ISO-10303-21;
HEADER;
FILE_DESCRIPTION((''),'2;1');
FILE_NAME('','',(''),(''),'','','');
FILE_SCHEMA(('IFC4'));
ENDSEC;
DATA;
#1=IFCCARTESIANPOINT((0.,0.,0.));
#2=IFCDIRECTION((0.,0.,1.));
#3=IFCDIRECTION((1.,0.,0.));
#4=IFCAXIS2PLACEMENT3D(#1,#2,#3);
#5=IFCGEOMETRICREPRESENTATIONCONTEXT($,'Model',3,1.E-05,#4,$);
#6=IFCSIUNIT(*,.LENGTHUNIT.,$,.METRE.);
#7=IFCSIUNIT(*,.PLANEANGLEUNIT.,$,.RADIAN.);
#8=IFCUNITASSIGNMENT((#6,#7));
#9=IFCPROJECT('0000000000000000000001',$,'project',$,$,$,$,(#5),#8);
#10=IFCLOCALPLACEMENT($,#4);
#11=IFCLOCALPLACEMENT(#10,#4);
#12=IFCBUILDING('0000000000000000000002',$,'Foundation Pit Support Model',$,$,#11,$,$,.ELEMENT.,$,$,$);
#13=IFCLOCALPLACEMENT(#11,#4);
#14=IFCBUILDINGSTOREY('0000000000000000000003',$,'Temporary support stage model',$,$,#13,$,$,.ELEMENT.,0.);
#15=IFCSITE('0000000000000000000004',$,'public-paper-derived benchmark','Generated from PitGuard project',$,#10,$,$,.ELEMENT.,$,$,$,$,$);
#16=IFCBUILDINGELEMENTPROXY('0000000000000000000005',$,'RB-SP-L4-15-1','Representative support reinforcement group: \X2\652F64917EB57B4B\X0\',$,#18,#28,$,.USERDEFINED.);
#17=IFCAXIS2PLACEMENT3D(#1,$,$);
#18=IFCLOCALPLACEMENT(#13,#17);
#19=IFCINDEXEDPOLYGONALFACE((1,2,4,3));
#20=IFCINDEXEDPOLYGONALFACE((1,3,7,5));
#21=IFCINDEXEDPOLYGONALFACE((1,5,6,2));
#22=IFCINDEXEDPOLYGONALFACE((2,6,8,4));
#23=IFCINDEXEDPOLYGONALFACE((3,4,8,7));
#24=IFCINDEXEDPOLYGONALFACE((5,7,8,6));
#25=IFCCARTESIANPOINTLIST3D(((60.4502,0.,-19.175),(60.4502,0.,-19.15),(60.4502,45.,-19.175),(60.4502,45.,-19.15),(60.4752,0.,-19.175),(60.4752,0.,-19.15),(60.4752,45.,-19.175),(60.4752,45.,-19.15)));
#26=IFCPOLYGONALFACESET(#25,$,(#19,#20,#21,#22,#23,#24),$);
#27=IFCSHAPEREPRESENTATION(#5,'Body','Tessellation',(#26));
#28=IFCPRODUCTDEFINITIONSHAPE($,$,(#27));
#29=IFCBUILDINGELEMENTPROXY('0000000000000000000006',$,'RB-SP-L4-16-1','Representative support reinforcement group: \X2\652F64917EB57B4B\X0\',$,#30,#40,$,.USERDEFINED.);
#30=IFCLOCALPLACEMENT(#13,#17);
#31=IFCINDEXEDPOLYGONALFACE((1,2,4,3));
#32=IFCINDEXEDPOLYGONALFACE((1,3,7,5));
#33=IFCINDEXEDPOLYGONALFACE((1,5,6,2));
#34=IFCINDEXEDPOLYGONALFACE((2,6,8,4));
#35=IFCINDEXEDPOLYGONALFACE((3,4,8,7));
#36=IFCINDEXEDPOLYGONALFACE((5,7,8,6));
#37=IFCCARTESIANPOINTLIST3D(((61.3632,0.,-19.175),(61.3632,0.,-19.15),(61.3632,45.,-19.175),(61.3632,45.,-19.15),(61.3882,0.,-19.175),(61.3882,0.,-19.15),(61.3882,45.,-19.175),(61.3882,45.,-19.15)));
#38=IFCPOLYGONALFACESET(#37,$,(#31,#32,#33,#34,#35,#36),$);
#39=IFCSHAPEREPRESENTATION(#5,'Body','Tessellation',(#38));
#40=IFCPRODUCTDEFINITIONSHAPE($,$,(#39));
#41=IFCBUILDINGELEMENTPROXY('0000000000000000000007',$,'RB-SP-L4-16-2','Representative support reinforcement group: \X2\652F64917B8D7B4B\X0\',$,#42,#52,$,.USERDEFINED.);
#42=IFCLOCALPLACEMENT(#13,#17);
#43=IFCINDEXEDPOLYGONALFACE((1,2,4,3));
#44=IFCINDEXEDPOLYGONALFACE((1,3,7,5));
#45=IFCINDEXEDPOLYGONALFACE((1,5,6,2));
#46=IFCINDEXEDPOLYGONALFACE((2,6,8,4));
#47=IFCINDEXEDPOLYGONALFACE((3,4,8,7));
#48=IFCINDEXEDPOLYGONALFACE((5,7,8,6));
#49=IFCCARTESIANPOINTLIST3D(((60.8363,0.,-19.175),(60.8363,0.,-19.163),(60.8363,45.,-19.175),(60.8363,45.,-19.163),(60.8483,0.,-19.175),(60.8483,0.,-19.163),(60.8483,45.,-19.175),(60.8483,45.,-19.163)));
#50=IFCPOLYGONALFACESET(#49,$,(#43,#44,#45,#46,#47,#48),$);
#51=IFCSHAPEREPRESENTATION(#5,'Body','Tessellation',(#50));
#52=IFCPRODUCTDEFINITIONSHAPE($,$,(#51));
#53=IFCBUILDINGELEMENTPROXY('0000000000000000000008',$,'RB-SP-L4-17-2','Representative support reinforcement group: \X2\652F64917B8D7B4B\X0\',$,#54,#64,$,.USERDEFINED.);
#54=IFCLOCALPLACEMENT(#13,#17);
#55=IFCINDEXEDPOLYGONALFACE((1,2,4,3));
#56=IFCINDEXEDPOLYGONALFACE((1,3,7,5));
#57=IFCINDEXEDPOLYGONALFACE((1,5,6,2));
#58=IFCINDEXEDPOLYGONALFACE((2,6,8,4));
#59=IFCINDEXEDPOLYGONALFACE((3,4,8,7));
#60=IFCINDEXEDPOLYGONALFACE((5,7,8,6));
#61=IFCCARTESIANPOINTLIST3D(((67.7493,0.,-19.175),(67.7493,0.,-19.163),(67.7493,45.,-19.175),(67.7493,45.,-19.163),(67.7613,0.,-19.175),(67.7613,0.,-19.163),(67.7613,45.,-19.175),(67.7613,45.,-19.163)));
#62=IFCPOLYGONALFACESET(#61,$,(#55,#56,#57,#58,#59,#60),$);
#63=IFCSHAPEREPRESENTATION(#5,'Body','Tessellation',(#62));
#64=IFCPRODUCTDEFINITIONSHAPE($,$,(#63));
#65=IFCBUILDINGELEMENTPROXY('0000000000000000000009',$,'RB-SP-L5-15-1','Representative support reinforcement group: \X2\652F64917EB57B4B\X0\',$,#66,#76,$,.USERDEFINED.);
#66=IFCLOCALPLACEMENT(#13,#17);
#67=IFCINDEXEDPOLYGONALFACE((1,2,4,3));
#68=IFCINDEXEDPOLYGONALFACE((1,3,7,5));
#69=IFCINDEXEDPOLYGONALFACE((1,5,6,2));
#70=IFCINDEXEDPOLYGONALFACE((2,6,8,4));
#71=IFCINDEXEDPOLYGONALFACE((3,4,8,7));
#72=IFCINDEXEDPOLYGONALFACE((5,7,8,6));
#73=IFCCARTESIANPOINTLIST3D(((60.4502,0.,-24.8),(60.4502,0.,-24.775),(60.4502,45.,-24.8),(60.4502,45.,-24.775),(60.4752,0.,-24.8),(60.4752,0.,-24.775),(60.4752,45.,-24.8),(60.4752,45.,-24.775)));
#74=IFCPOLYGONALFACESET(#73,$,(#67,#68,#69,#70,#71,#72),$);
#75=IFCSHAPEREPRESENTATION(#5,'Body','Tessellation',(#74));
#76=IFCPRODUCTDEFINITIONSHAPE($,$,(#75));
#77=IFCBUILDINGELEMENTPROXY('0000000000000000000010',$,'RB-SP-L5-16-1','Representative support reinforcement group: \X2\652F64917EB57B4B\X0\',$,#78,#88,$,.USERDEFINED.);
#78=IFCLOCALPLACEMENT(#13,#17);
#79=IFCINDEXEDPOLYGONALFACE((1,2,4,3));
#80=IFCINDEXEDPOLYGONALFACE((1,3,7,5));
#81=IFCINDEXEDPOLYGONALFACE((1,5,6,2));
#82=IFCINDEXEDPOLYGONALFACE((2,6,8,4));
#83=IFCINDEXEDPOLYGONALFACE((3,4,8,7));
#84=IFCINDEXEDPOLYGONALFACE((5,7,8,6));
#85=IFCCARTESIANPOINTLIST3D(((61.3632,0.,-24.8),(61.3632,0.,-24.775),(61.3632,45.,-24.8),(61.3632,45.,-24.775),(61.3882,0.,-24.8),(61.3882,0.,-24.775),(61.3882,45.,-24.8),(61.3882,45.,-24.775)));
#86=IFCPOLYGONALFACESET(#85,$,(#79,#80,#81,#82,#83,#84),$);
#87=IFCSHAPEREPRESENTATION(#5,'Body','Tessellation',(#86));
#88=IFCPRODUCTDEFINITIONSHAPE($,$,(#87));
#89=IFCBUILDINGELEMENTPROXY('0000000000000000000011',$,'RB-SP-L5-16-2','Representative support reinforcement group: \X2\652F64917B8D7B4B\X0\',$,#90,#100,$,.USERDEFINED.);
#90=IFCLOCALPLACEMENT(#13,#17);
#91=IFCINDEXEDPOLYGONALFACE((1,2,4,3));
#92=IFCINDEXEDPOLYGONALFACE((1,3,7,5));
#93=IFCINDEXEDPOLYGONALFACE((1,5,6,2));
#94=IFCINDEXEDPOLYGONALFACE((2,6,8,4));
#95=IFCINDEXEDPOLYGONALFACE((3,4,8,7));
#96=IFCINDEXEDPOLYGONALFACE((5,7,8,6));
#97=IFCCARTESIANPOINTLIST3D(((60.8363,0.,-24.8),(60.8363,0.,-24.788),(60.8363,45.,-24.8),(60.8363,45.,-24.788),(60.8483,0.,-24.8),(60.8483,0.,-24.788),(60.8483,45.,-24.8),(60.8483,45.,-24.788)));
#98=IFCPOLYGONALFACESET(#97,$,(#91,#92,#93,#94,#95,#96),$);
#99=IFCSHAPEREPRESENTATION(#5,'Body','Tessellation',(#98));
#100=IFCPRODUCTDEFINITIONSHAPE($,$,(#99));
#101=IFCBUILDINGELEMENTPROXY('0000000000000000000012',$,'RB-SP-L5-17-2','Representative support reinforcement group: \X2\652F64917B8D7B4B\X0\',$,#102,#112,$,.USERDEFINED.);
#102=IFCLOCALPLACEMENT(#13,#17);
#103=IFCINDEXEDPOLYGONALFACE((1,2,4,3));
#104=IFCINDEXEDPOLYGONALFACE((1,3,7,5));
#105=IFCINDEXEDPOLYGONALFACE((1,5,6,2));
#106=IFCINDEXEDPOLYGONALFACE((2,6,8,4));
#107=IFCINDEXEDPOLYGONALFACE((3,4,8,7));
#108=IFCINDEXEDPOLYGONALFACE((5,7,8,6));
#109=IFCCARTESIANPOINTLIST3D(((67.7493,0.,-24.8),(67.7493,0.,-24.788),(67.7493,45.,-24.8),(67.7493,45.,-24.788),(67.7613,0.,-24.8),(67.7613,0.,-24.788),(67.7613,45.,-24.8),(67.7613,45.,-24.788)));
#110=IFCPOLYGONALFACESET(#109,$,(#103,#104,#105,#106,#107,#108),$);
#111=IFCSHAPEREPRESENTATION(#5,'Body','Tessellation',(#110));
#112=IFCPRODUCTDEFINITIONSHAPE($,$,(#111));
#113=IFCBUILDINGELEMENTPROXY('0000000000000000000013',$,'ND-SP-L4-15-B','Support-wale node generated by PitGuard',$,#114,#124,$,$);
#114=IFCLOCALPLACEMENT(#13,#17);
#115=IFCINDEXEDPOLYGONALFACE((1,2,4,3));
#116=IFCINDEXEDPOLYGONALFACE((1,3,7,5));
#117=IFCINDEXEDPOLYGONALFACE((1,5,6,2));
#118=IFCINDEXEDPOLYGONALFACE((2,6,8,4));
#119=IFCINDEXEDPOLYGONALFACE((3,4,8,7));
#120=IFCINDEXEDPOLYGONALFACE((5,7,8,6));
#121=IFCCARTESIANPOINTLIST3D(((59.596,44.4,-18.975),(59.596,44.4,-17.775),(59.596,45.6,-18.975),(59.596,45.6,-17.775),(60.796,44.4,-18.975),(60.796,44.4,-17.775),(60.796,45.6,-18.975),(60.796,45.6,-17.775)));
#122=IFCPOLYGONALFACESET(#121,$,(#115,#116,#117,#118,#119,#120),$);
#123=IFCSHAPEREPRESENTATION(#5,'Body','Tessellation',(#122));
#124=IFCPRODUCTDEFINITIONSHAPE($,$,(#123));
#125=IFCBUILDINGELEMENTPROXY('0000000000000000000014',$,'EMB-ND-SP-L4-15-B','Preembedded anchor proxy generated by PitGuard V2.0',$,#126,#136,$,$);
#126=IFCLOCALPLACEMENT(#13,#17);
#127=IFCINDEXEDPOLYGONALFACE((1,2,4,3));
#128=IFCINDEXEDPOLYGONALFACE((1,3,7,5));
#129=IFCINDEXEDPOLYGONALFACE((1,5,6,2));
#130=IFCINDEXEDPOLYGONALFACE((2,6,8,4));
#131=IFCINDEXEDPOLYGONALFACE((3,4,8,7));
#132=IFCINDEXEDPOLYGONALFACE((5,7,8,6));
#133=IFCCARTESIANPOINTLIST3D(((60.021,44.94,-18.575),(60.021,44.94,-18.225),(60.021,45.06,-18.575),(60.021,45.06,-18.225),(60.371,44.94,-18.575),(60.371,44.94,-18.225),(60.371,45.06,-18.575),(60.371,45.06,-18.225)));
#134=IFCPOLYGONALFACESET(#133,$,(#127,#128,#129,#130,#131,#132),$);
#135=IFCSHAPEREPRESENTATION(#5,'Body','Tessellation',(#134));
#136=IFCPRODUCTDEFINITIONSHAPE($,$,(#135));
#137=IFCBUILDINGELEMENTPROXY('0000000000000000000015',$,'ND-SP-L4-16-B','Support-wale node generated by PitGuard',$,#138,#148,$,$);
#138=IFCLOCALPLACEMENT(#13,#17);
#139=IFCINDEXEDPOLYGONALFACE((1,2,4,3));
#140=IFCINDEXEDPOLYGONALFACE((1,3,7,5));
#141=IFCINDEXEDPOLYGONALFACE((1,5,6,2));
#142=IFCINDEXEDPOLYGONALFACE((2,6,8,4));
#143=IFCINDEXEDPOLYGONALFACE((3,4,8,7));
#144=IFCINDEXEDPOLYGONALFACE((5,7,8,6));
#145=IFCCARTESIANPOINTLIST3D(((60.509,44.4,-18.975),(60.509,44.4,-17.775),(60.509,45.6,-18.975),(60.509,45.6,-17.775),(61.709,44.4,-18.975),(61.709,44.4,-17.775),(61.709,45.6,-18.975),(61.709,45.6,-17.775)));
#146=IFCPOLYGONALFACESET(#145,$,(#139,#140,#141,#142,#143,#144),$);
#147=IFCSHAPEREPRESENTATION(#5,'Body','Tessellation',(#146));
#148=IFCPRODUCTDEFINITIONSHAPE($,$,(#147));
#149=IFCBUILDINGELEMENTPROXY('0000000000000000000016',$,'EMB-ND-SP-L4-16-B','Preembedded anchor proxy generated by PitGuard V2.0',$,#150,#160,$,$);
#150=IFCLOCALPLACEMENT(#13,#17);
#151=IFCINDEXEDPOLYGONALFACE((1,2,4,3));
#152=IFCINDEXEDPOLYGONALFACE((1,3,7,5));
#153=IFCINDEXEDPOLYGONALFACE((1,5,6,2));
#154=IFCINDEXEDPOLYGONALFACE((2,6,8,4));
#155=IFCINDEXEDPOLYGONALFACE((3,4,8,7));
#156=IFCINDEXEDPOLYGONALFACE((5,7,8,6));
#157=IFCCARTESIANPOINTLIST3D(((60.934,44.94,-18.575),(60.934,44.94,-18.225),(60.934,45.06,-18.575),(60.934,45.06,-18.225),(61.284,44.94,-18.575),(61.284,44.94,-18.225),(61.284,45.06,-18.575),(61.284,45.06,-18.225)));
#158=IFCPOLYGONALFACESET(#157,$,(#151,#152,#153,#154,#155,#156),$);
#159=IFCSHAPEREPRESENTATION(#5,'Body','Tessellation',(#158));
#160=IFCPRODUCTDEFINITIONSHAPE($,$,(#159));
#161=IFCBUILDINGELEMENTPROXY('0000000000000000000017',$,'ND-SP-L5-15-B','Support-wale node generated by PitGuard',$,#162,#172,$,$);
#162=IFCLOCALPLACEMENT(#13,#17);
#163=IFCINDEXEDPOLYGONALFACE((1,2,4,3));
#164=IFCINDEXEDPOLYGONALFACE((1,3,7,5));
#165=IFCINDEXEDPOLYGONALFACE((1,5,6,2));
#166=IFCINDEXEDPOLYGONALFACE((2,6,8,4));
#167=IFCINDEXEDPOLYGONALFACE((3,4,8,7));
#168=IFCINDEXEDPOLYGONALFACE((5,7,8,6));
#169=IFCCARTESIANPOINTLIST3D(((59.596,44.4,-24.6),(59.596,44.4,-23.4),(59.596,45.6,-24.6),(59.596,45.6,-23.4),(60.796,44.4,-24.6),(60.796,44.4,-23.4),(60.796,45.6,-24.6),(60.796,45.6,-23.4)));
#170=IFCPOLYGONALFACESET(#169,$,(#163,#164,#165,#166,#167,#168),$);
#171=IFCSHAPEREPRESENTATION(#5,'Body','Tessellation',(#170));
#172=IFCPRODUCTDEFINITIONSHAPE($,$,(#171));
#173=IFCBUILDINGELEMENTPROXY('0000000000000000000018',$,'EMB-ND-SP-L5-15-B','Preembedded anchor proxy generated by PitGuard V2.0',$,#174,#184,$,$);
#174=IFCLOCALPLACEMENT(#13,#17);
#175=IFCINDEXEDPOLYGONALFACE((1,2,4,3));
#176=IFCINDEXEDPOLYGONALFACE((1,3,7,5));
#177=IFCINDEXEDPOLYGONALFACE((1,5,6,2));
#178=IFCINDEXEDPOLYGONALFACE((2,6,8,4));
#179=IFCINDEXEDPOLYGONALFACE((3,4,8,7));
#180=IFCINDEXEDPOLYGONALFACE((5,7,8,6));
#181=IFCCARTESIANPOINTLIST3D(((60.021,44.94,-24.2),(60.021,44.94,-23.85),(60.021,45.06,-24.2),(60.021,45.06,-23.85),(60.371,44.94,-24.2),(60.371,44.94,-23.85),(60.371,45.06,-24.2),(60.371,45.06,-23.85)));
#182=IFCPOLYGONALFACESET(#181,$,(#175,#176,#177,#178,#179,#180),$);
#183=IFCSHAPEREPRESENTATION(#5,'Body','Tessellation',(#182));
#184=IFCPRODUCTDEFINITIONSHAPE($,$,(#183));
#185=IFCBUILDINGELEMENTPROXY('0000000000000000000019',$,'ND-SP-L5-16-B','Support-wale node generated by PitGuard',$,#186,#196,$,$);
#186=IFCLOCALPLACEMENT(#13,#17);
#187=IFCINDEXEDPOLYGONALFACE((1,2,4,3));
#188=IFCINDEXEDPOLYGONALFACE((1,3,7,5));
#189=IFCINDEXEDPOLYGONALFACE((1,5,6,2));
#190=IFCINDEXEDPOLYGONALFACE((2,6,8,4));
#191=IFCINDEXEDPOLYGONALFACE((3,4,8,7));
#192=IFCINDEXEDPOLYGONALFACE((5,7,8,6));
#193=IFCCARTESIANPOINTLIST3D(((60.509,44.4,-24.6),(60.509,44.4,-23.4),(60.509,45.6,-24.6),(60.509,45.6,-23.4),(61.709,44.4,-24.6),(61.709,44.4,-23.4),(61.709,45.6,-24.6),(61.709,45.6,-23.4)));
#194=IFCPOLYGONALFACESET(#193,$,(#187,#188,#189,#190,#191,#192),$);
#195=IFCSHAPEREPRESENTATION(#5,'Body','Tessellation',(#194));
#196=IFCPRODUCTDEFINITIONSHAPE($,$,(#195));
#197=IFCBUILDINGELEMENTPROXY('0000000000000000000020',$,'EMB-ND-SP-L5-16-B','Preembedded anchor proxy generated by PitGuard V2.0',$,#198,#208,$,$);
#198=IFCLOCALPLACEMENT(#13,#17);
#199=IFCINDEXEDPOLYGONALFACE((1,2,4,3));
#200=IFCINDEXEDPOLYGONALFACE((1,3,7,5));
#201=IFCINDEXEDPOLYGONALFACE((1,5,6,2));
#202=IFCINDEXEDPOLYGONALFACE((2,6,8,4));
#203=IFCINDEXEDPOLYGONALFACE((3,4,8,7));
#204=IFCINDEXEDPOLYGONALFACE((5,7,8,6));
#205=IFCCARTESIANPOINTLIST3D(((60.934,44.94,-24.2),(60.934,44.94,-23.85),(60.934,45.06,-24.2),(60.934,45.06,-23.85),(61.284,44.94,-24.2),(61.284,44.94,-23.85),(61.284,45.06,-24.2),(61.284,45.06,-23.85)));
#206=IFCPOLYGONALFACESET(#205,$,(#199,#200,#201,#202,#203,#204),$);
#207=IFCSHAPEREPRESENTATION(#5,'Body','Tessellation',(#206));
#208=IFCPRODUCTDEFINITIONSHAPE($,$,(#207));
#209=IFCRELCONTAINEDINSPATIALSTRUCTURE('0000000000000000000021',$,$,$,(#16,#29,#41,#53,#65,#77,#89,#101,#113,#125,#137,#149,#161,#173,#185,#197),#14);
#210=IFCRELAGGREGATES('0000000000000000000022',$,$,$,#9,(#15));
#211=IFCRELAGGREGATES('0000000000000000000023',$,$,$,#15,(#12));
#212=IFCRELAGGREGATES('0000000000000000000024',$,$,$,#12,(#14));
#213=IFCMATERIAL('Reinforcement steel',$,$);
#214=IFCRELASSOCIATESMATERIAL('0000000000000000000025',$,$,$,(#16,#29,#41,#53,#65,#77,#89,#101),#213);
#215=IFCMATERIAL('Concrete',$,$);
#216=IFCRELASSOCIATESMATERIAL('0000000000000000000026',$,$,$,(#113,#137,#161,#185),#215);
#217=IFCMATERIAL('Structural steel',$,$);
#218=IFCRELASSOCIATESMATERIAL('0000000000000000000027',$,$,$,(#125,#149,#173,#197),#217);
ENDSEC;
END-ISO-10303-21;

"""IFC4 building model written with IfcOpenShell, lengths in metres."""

from ifc_helpers import new_model, si_unit, frame, origin_with_axes, origin_2d, place, context, project, spatial, rectangle, extrude, material, element, save


model = new_model("IFC4")

# Units and contexts
model_context = context("Model", 3, precision=1e-05, world=origin_with_axes())
ifc_project = project(units=[si_unit("LENGTHUNIT", "METRE"), si_unit("PLANEANGLEUNIT", "RADIAN")], contexts=[model_context])

# Site, building, storey
site_placement = place(None, origin_with_axes())
site = spatial("IfcSite", under=ifc_project, at=site_placement, Name="public-paper-derived benchmark", Description="Generated from PitGuard project", CompositionType="ELEMENT")
building_placement = place(site_placement, origin_with_axes())
building = spatial("IfcBuilding", under=site, at=building_placement, Name="Foundation Pit Support Model", CompositionType="ELEMENT")
storey_placement = place(building_placement, origin_with_axes())
storey = spatial("IfcBuildingStorey", under=building, at=storey_placement, Name="Temporary support stage model", CompositionType="ELEMENT", Elevation=0.0)

# Shared definitions
ifc_material_1 = material(Name="Structural steel")

# Shared definitions
ifc_material_2 = material(Name="Concrete")

# Building element proxies
ifc_material_3 = material(Name="Reinforcement steel")
for number, where, z_axis, x_axis, name in (
    (1, (60.4627, 22.5, -19.175), (0.0, 0.0, 1.0), (0.0, 1.0, 0.0), "RB-SP-L4-15-1"),
    (2, (61.3757, 22.5, -19.175), (0.0, 0.0, 1.0), (0.0, 1.0, 0.0), "RB-SP-L4-16-1"),
):
    element("IfcBuildingElementProxy", number, at=place(storey_placement, frame(where, z_axis=z_axis, x_axis=x_axis)), inside=storey, material=ifc_material_3, Name=name, Description="Representative support reinforcement group: 支撑纵筋", PredefinedType="USERDEFINED", context=model_context, shape_type="SweptSolid", body=[
        extrude(rectangle(XDim=45.0, YDim=0.025, at=origin_2d()), origin_with_axes(), (0.0, 0.0, 1.0), 0.025),
    ])
for number, where, z_axis, x_axis, name in (
    (3, (60.8423, 22.5, -19.175), (0.0, 0.0, 1.0), (0.0, 1.0, 0.0), "RB-SP-L4-16-2"),
    (4, (67.7553, 22.5, -19.175), (0.0, 0.0, 1.0), (0.0, 1.0, 0.0), "RB-SP-L4-17-2"),
):
    element("IfcBuildingElementProxy", number, at=place(storey_placement, frame(where, z_axis=z_axis, x_axis=x_axis)), inside=storey, material=ifc_material_3, Name=name, Description="Representative support reinforcement group: 支撑箍筋", PredefinedType="USERDEFINED", context=model_context, shape_type="SweptSolid", body=[
        extrude(rectangle(XDim=45.0, YDim=0.012, at=origin_2d()), origin_with_axes(), (0.0, 0.0, 1.0), 0.012),
    ])
for number, where, z_axis, x_axis, name in (
    (5, (60.4627, 22.5, -24.8), (0.0, 0.0, 1.0), (0.0, 1.0, 0.0), "RB-SP-L5-15-1"),
    (6, (61.3757, 22.5, -24.8), (0.0, 0.0, 1.0), (0.0, 1.0, 0.0), "RB-SP-L5-16-1"),
):
    element("IfcBuildingElementProxy", number, at=place(storey_placement, frame(where, z_axis=z_axis, x_axis=x_axis)), inside=storey, material=ifc_material_3, Name=name, Description="Representative support reinforcement group: 支撑纵筋", PredefinedType="USERDEFINED", context=model_context, shape_type="SweptSolid", body=[
        extrude(rectangle(XDim=45.0, YDim=0.025, at=origin_2d()), origin_with_axes(), (0.0, 0.0, 1.0), 0.025),
    ])
for number, where, z_axis, x_axis, name in (
    (7, (60.8423, 22.5, -24.8), (0.0, 0.0, 1.0), (0.0, 1.0, 0.0), "RB-SP-L5-16-2"),
    (8, (67.7553, 22.5, -24.8), (0.0, 0.0, 1.0), (0.0, 1.0, 0.0), "RB-SP-L5-17-2"),
):
    element("IfcBuildingElementProxy", number, at=place(storey_placement, frame(where, z_axis=z_axis, x_axis=x_axis)), inside=storey, material=ifc_material_3, Name=name, Description="Representative support reinforcement group: 支撑箍筋", PredefinedType="USERDEFINED", context=model_context, shape_type="SweptSolid", body=[
        extrude(rectangle(XDim=45.0, YDim=0.012, at=origin_2d()), origin_with_axes(), (0.0, 0.0, 1.0), 0.012),
    ])
proxy_1_placement = place(storey_placement, frame((60.196, 45.0, -18.975), z_axis=(0.0, 0.0, 1.0), x_axis=(1.0, 0.0, 0.0)))
element("IfcBuildingElementProxy", 9, at=proxy_1_placement, inside=storey, material=ifc_material_2, Name="ND-SP-L4-15-B", Description="Support-wale node generated by PitGuard", context=model_context, shape_type="SweptSolid", body=[
    extrude(rectangle(XDim=1.2, YDim=1.2, at=origin_2d()), origin_with_axes(), (0.0, 0.0, 1.0), 1.2),
])
proxy_2_placement = place(storey_placement, frame((60.196, 45.0, -18.575), z_axis=(0.0, 0.0, 1.0), x_axis=(1.0, 0.0, 0.0)))
element("IfcBuildingElementProxy", 10, at=proxy_2_placement, inside=storey, material=ifc_material_1, Name="EMB-ND-SP-L4-15-B", Description="Preembedded anchor proxy generated by PitGuard V2.0", context=model_context, shape_type="SweptSolid", body=[
    extrude(rectangle(XDim=0.35, YDim=0.12, at=origin_2d()), origin_with_axes(), (0.0, 0.0, 1.0), 0.35),
])
proxy_3_placement = place(storey_placement, frame((61.109, 45.0, -18.975), z_axis=(0.0, 0.0, 1.0), x_axis=(1.0, 0.0, 0.0)))
element("IfcBuildingElementProxy", 11, at=proxy_3_placement, inside=storey, material=ifc_material_2, Name="ND-SP-L4-16-B", Description="Support-wale node generated by PitGuard", context=model_context, shape_type="SweptSolid", body=[
    extrude(rectangle(XDim=1.2, YDim=1.2, at=origin_2d()), origin_with_axes(), (0.0, 0.0, 1.0), 1.2),
])
proxy_4_placement = place(storey_placement, frame((61.109, 45.0, -18.575), z_axis=(0.0, 0.0, 1.0), x_axis=(1.0, 0.0, 0.0)))
element("IfcBuildingElementProxy", 12, at=proxy_4_placement, inside=storey, material=ifc_material_1, Name="EMB-ND-SP-L4-16-B", Description="Preembedded anchor proxy generated by PitGuard V2.0", context=model_context, shape_type="SweptSolid", body=[
    extrude(rectangle(XDim=0.35, YDim=0.12, at=origin_2d()), origin_with_axes(), (0.0, 0.0, 1.0), 0.35),
])
proxy_5_placement = place(storey_placement, frame((60.196, 45.0, -24.6), z_axis=(0.0, 0.0, 1.0), x_axis=(1.0, 0.0, 0.0)))
element("IfcBuildingElementProxy", 13, at=proxy_5_placement, inside=storey, material=ifc_material_2, Name="ND-SP-L5-15-B", Description="Support-wale node generated by PitGuard", context=model_context, shape_type="SweptSolid", body=[
    extrude(rectangle(XDim=1.2, YDim=1.2, at=origin_2d()), origin_with_axes(), (0.0, 0.0, 1.0), 1.2),
])
proxy_6_placement = place(storey_placement, frame((60.196, 45.0, -24.2), z_axis=(0.0, 0.0, 1.0), x_axis=(1.0, 0.0, 0.0)))
element("IfcBuildingElementProxy", 14, at=proxy_6_placement, inside=storey, material=ifc_material_1, Name="EMB-ND-SP-L5-15-B", Description="Preembedded anchor proxy generated by PitGuard V2.0", context=model_context, shape_type="SweptSolid", body=[
    extrude(rectangle(XDim=0.35, YDim=0.12, at=origin_2d()), origin_with_axes(), (0.0, 0.0, 1.0), 0.35),
])
proxy_7_placement = place(storey_placement, frame((61.109, 45.0, -24.6), z_axis=(0.0, 0.0, 1.0), x_axis=(1.0, 0.0, 0.0)))
element("IfcBuildingElementProxy", 15, at=proxy_7_placement, inside=storey, material=ifc_material_2, Name="ND-SP-L5-16-B", Description="Support-wale node generated by PitGuard", context=model_context, shape_type="SweptSolid", body=[
    extrude(rectangle(XDim=1.2, YDim=1.2, at=origin_2d()), origin_with_axes(), (0.0, 0.0, 1.0), 1.2),
])
proxy_8_placement = place(storey_placement, frame((61.109, 45.0, -24.2), z_axis=(0.0, 0.0, 1.0), x_axis=(1.0, 0.0, 0.0)))
element("IfcBuildingElementProxy", 16, at=proxy_8_placement, inside=storey, material=ifc_material_1, Name="EMB-ND-SP-L5-16-B", Description="Preembedded anchor proxy generated by PitGuard V2.0", context=model_context, shape_type="SweptSolid", body=[
    extrude(rectangle(XDim=0.35, YDim=0.12, at=origin_2d()), origin_with_axes(), (0.0, 0.0, 1.0), 0.35),
])

save(model, "model.ifc")
